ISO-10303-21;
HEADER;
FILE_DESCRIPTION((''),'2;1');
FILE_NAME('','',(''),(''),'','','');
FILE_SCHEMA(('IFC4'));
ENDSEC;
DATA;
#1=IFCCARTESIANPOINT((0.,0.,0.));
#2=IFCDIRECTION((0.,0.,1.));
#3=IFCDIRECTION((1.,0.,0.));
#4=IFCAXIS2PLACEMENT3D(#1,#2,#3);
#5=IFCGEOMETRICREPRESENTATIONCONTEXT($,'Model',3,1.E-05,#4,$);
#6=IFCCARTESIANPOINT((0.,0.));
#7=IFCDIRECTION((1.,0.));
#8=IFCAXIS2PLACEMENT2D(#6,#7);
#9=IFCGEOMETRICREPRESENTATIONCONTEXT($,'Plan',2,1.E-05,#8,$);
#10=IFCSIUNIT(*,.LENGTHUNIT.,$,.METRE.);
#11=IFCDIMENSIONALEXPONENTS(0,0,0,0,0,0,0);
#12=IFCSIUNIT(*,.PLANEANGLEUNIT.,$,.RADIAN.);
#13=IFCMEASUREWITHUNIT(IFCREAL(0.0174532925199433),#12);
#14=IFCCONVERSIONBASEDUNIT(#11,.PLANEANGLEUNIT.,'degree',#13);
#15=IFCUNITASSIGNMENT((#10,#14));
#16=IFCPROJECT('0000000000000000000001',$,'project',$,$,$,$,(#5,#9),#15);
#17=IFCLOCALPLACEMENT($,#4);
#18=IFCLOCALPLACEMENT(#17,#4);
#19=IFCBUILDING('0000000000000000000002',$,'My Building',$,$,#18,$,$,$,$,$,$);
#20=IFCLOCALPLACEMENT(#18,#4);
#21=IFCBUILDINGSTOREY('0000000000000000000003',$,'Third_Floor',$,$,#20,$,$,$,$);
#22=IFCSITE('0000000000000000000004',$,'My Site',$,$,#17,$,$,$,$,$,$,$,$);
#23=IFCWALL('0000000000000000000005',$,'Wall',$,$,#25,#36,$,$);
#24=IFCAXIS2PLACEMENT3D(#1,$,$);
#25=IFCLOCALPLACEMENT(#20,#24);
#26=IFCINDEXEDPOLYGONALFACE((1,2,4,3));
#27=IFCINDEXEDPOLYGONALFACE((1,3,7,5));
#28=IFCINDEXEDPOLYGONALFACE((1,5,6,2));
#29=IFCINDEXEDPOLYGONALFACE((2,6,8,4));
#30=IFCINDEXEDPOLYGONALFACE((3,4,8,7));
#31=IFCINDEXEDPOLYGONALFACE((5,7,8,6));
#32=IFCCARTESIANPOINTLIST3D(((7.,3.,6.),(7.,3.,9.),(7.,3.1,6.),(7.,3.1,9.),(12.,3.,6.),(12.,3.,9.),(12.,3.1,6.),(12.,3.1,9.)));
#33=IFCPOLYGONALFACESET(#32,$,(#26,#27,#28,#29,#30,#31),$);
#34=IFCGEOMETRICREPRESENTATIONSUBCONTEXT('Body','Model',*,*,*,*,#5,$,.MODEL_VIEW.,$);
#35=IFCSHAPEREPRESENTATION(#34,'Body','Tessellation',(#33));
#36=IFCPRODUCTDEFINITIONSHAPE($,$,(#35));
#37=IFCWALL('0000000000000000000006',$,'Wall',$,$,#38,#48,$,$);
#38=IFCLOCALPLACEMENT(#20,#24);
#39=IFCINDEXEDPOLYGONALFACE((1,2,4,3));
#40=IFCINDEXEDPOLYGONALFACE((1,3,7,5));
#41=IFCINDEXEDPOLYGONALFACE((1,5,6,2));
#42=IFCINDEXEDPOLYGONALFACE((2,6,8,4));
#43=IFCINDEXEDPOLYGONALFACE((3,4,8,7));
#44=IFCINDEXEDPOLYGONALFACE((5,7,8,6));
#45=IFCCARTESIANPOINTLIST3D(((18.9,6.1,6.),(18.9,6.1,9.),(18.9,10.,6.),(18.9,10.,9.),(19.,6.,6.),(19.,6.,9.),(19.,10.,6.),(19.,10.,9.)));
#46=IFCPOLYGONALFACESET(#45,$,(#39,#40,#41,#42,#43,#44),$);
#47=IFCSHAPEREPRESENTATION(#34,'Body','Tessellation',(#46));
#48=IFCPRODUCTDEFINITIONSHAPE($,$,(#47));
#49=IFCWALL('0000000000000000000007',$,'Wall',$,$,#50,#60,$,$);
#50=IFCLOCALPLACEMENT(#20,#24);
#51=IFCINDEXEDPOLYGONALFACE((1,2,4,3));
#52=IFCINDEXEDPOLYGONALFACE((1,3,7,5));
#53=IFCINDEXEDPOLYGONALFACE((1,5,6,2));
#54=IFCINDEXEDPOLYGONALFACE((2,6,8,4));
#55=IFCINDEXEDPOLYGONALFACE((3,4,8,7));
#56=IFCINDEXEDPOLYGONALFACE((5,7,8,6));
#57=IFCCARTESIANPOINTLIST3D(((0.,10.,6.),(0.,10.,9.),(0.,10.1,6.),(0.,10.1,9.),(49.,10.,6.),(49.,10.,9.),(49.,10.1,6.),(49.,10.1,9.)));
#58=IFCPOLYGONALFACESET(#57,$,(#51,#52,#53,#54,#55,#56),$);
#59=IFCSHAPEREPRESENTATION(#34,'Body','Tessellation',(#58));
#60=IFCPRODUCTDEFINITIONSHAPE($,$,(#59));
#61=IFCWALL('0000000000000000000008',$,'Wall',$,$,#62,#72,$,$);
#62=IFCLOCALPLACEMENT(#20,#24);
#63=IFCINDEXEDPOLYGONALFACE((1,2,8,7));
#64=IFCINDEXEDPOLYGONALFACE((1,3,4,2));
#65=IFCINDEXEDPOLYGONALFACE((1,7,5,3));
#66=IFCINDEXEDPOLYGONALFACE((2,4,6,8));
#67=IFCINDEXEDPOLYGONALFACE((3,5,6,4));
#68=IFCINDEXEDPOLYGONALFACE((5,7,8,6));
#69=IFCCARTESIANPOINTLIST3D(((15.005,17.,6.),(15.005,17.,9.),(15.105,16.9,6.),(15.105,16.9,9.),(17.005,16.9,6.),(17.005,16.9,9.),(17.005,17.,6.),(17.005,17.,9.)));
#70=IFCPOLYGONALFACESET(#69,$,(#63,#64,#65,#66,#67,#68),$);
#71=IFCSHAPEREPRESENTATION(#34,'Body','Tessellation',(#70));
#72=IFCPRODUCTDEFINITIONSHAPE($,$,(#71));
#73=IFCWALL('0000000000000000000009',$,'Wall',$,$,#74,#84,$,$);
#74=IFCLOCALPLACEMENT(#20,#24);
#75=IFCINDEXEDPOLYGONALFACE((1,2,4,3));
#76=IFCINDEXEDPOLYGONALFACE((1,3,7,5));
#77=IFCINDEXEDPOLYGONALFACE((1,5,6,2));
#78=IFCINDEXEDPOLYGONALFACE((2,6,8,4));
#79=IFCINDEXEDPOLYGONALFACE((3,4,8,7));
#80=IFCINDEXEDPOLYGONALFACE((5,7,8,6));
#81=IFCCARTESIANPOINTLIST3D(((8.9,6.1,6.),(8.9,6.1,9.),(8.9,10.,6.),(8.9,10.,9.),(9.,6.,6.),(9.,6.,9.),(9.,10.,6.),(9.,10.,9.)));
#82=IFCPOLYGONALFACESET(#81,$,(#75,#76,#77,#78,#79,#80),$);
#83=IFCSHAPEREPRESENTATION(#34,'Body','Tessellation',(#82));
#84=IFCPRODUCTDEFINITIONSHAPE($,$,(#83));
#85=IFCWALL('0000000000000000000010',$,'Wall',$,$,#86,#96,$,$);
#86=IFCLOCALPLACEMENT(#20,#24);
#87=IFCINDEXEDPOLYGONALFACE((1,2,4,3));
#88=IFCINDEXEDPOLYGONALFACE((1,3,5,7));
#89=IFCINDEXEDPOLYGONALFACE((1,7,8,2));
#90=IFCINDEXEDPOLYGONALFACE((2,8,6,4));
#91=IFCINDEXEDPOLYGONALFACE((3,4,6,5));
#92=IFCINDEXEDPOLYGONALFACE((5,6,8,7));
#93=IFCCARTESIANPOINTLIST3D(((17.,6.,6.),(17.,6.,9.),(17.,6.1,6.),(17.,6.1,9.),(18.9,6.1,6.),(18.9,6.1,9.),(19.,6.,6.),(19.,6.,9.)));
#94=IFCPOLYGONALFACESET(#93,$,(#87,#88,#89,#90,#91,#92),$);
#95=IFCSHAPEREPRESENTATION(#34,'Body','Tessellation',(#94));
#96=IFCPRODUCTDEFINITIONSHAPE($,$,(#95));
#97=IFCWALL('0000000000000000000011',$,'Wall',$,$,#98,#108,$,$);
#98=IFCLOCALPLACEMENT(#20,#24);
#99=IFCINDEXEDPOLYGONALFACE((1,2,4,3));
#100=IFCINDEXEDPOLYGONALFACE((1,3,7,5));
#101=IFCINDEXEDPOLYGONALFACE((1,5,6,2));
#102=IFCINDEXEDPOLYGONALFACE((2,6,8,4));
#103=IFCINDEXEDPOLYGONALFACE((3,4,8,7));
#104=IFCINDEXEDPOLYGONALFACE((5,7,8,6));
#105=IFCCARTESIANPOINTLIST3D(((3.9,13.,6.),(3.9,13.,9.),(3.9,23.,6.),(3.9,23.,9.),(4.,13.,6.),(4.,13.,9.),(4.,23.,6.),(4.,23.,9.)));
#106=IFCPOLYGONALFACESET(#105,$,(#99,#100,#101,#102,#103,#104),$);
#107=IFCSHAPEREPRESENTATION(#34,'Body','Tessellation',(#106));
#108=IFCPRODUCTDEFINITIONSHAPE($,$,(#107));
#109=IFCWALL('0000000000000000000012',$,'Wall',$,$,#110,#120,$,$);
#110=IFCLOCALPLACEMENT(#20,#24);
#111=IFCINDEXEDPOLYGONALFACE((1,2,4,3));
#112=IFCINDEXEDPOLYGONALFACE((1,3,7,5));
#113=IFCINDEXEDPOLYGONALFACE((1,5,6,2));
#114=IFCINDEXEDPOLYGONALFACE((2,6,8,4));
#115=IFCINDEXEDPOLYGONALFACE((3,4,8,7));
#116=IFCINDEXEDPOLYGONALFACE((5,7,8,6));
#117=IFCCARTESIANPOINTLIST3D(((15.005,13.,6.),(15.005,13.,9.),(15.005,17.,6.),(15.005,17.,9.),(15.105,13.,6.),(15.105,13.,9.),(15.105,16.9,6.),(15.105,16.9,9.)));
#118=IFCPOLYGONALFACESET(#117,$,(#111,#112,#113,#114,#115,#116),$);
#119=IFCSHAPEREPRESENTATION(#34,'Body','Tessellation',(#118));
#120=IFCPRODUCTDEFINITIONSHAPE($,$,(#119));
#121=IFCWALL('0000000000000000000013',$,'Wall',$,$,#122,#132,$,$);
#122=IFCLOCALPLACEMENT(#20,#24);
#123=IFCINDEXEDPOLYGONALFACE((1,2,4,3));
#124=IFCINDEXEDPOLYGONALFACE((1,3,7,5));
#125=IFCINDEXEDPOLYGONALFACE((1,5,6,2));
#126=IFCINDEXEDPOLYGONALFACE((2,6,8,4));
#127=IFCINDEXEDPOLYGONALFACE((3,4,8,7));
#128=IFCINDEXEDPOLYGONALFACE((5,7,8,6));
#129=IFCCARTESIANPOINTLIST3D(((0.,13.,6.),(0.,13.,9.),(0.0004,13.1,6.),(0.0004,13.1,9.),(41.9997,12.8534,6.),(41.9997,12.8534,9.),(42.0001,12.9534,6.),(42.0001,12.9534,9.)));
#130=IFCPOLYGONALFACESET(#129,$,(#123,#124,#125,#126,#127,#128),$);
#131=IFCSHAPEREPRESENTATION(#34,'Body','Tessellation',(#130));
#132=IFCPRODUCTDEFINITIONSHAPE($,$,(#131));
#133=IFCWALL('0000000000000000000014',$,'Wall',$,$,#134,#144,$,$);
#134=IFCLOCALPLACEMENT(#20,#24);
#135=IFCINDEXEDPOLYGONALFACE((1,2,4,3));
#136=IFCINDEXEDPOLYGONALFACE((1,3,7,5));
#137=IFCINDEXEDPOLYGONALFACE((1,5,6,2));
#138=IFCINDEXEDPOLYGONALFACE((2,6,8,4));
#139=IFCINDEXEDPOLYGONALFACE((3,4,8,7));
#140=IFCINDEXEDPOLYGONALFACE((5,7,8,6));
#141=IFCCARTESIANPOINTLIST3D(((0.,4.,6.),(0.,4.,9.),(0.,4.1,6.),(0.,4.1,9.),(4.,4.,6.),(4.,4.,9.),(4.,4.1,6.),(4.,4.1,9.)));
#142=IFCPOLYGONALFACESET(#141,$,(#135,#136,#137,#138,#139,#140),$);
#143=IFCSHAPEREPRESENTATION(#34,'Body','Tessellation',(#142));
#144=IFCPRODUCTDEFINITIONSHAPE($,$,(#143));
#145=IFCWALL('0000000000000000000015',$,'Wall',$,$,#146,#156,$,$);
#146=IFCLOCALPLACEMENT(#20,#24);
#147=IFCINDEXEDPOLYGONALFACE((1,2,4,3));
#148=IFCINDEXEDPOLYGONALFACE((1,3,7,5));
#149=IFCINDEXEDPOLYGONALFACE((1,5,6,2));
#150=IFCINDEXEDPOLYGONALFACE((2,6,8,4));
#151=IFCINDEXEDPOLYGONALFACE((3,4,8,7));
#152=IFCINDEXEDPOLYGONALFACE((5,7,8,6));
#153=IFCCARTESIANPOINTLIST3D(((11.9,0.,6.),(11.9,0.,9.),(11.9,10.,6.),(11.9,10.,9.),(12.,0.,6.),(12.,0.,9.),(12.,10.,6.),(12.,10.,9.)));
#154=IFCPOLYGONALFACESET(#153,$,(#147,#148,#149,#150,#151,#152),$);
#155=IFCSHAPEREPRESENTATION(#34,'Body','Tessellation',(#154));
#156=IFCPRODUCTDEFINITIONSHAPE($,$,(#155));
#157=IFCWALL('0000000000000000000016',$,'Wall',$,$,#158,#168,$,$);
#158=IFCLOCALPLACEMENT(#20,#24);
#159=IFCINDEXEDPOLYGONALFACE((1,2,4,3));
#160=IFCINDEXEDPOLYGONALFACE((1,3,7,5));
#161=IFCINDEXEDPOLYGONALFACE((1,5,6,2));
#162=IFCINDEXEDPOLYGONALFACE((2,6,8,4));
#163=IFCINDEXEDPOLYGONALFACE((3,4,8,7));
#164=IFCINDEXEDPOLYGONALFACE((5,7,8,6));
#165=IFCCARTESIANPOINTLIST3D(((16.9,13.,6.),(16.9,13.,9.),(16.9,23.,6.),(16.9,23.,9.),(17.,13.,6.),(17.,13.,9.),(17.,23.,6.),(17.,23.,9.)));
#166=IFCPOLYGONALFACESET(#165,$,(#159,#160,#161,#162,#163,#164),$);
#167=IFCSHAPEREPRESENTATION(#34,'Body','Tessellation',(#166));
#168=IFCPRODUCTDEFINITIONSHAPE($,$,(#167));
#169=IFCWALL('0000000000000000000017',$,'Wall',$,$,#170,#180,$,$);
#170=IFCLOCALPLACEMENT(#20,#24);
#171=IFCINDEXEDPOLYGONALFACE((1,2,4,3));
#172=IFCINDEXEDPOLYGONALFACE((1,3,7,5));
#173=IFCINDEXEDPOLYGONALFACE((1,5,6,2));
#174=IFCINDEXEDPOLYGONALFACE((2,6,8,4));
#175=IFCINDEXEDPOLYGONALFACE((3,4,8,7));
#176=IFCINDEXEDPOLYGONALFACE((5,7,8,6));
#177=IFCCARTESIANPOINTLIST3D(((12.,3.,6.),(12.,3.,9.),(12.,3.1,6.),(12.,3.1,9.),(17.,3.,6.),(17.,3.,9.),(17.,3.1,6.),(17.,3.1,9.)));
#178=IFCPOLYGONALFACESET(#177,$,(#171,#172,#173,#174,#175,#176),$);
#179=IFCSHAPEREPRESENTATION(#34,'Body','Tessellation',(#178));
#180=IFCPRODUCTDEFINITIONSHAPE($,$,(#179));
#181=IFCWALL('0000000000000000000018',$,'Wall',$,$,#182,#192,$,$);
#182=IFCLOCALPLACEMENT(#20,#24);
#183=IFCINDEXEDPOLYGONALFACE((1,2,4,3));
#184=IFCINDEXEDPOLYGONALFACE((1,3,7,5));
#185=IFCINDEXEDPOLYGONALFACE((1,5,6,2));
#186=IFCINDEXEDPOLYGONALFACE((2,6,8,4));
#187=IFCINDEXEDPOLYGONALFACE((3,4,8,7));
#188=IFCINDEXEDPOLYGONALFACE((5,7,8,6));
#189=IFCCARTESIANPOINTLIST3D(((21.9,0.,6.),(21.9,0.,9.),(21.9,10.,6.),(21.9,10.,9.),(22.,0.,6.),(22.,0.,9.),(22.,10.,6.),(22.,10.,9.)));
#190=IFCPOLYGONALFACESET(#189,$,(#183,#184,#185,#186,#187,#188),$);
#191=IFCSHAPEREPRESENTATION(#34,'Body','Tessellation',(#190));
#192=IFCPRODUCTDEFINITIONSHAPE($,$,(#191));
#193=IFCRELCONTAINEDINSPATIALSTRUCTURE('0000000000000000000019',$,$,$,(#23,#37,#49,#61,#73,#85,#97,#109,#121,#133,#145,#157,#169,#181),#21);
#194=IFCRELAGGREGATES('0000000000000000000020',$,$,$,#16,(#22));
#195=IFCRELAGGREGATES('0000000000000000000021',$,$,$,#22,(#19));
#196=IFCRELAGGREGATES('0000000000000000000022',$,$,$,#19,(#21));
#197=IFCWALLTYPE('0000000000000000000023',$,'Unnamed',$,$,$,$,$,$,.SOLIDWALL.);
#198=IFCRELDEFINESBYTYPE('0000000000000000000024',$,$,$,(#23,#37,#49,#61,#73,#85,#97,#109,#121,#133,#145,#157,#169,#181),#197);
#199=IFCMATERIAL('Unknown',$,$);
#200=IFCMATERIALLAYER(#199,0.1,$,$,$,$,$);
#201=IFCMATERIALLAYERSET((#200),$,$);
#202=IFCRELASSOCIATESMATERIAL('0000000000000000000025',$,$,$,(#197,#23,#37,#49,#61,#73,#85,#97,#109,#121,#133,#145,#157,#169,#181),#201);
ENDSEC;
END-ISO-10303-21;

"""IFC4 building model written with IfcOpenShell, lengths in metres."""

from ifc_helpers import new_model, entity, si_unit, converted_unit, frame, origin_with_axes, origin_2d_with_axis, place, context, subcontext, project, spatial, line, indexed_curve, outline, extrude, material, layer, layer_set, layer_usage, type_object, element, save


model = new_model("IFC4")

# Units and contexts
model_context = context("Model", 3, precision=1e-05, world=origin_with_axes())
plan_context = context("Plan", 2, precision=1e-05, world=origin_2d_with_axis())
body_context = subcontext(model_context, "Body", "Model", "MODEL_VIEW")
ifc_project = project(units=[si_unit("LENGTHUNIT", "METRE"), converted_unit("PLANEANGLEUNIT", "degree", entity("IfcReal", 0.0174532925199433), si_unit("PLANEANGLEUNIT", "RADIAN"), dimensions=[0, 0, 0, 0, 0, 0, 0])], contexts=[model_context, plan_context])

# Site, building, storey
site_placement = place(None, origin_with_axes())
site = spatial("IfcSite", under=ifc_project, at=site_placement, Name="My Site")
building_placement = place(site_placement, origin_with_axes())
building = spatial("IfcBuilding", under=site, at=building_placement, Name="My Building")
storey_placement = place(building_placement, origin_with_axes())
storey = spatial("IfcBuildingStorey", under=building, at=storey_placement, Name="Third_Floor")

# Shared definitions
ifc_material = material(Name="Unknown")

# Walls
ifc_layer_1 = layer(ifc_material, 0.1)
ifc_layer_set_1 = layer_set([ifc_layer_1])
wall_type = type_object("IfcWallType", Name="Unnamed", PredefinedType="SOLIDWALL", material=ifc_layer_set_1)
ifc_layer_usage_1 = layer_usage(ifc_layer_set_1, "AXIS2", "POSITIVE", 0.0)
wall_1_placement = place(storey_placement, frame((7.0, 3.0, 6.0), z_axis=(0.0, 0.0, 1.0), x_axis=(1.0, 0.0, 0.0)))
element("IfcWall", 1, at=wall_1_placement, inside=storey, type_object=wall_type, material=ifc_layer_usage_1, Name="Wall", context=body_context, shape_type="SweptSolid", body=[
    extrude(outline(indexed_curve([(0.0, 0.0), (0.0, 0.1), (5.0, 0.1), (5.0, 0.0)], segments=[line(1, 2, 3, 4, 1)])), origin_with_axes(), (0.0, 0.0, 1.0), 3.0),
])
ifc_layer_usage_2 = layer_usage(ifc_layer_set_1, "AXIS2", "POSITIVE", 0.0)
wall_2_placement = place(storey_placement, frame((19.0, 6.0, 6.0), z_axis=(0.0, 0.0, 1.0), x_axis=(0.0, 1.0, 0.0)))
element("IfcWall", 2, at=wall_2_placement, inside=storey, type_object=wall_type, material=ifc_layer_usage_2, Name="Wall", context=body_context, shape_type="SweptSolid", body=[
    extrude(outline(indexed_curve([(0.0, 0.0), (0.1, 0.1), (4.0, 0.1), (4.0, 0.0)], segments=[line(1, 2, 3, 4, 1)])), origin_with_axes(), (0.0, 0.0, 1.0), 3.0),
])
ifc_layer_usage_3 = layer_usage(ifc_layer_set_1, "AXIS2", "POSITIVE", 0.0)
wall_3_placement = place(storey_placement, frame((0.0, 10.0, 6.0), z_axis=(0.0, 0.0, 1.0), x_axis=(1.0, 0.0, 0.0)))
element("IfcWall", 3, at=wall_3_placement, inside=storey, type_object=wall_type, material=ifc_layer_usage_3, Name="Wall", context=body_context, shape_type="SweptSolid", body=[
    extrude(outline(indexed_curve([(0.0, 0.0), (0.0, 0.1), (49.0, 0.1), (49.0, 0.0)], segments=[line(1, 2, 3, 4, 1)])), origin_with_axes(), (0.0, 0.0, 1.0), 3.0),
])
ifc_layer_usage_4 = layer_usage(ifc_layer_set_1, "AXIS2", "POSITIVE", 0.0)
wall_4_placement = place(storey_placement, frame((17.005, 17.0, 6.0), z_axis=(0.0, 0.0, 1.0), x_axis=(-1.0, 0.0, 0.0)))
element("IfcWall", 4, at=wall_4_placement, inside=storey, type_object=wall_type, material=ifc_layer_usage_4, Name="Wall", context=body_context, shape_type="SweptSolid", body=[
    extrude(outline(indexed_curve([(0.0, 0.0), (0.0, 0.1), (1.9, 0.1), (2.0, 0.0)], segments=[line(1, 2, 3, 4, 1)])), origin_with_axes(), (0.0, 0.0, 1.0), 3.0),
])
ifc_layer_usage_5 = layer_usage(ifc_layer_set_1, "AXIS2", "POSITIVE", 0.0)
wall_5_placement = place(storey_placement, frame((9.0, 6.0, 6.0), z_axis=(0.0, 0.0, 1.0), x_axis=(0.0, 1.0, 0.0)))
element("IfcWall", 5, at=wall_5_placement, inside=storey, type_object=wall_type, material=ifc_layer_usage_5, Name="Wall", context=body_context, shape_type="SweptSolid", body=[
    extrude(outline(indexed_curve([(0.0, 0.0), (0.1, 0.1), (4.0, 0.1), (4.0, 0.0)], segments=[line(1, 2, 3, 4, 1)])), origin_with_axes(), (0.0, 0.0, 1.0), 3.0),
])
ifc_layer_usage_6 = layer_usage(ifc_layer_set_1, "AXIS2", "POSITIVE", 0.0)
wall_6_placement = place(storey_placement, frame((17.0, 6.0, 6.0), z_axis=(0.0, 0.0, 1.0), x_axis=(1.0, 0.0, 0.0)))
element("IfcWall", 6, at=wall_6_placement, inside=storey, type_object=wall_type, material=ifc_layer_usage_6, Name="Wall", context=body_context, shape_type="SweptSolid", body=[
    extrude(outline(indexed_curve([(0.0, 0.0), (0.0, 0.1), (1.9, 0.1), (2.0, 0.0)], segments=[line(1, 2, 3, 4, 1)])), origin_with_axes(), (0.0, 0.0, 1.0), 3.0),
])
ifc_layer_usage_7 = layer_usage(ifc_layer_set_1, "AXIS2", "POSITIVE", 0.0)
wall_7_placement = place(storey_placement, frame((3.9, 23.0, 6.0), z_axis=(0.0, 0.0, 1.0), x_axis=(0.0, -1.0, 0.0)))
element("IfcWall", 7, at=wall_7_placement, inside=storey, type_object=wall_type, material=ifc_layer_usage_7, Name="Wall", context=body_context, shape_type="SweptSolid", body=[
    extrude(outline(indexed_curve([(0.0, 0.0), (0.0, 0.1), (10.0, 0.1), (10.0, 0.0)], segments=[line(1, 2, 3, 4, 1)])), origin_with_axes(), (0.0, 0.0, 1.0), 3.0),
])
ifc_layer_usage_8 = layer_usage(ifc_layer_set_1, "AXIS2", "POSITIVE", 0.0)
wall_8_placement = place(storey_placement, frame((15.005, 17.0, 6.0), z_axis=(0.0, 0.0, 1.0), x_axis=(0.0, -1.0, 0.0)))
element("IfcWall", 8, at=wall_8_placement, inside=storey, type_object=wall_type, material=ifc_layer_usage_8, Name="Wall", context=body_context, shape_type="SweptSolid", body=[
    extrude(outline(indexed_curve([(0.0, 0.0), (0.1, 0.1), (4.0, 0.1), (4.0, 0.0)], segments=[line(1, 2, 3, 4, 1)])), origin_with_axes(), (0.0, 0.0, 1.0), 3.0),
])
ifc_layer_usage_9 = layer_usage(ifc_layer_set_1, "AXIS2", "POSITIVE", 0.0)
wall_9_placement = place(storey_placement, frame((0.0, 13.0, 6.0), z_axis=(0.0, 0.0, 1.0), x_axis=(0.999994, -0.003491, 0.0)))
element("IfcWall", 9, at=wall_9_placement, inside=storey, type_object=wall_type, material=ifc_layer_usage_9, Name="Wall", context=body_context, shape_type="SweptSolid", body=[
    extrude(outline(indexed_curve([(0.0, 0.0), (0.0, 0.1), (42.0, 0.1), (42.0, 0.0)], segments=[line(1, 2, 3, 4, 1)])), origin_with_axes(), (0.0, 0.0, 1.0), 3.0),
])
ifc_layer_usage_10 = layer_usage(ifc_layer_set_1, "AXIS2", "POSITIVE", 0.0)
wall_10_placement = place(storey_placement, frame((0.0, 4.0, 6.0), z_axis=(0.0, 0.0, 1.0), x_axis=(1.0, 0.0, 0.0)))
element("IfcWall", 10, at=wall_10_placement, inside=storey, type_object=wall_type, material=ifc_layer_usage_10, Name="Wall", context=body_context, shape_type="SweptSolid", body=[
    extrude(outline(indexed_curve([(0.0, 0.0), (0.0, 0.1), (4.0, 0.1), (4.0, 0.0)], segments=[line(1, 2, 3, 4, 1)])), origin_with_axes(), (0.0, 0.0, 1.0), 3.0),
])
ifc_layer_usage_11 = layer_usage(ifc_layer_set_1, "AXIS2", "POSITIVE", 0.0)
wall_11_placement = place(storey_placement, frame((11.9, 10.0, 6.0), z_axis=(0.0, 0.0, 1.0), x_axis=(0.0, -1.0, 0.0)))
element("IfcWall", 11, at=wall_11_placement, inside=storey, type_object=wall_type, material=ifc_layer_usage_11, Name="Wall", context=body_context, shape_type="SweptSolid", body=[
    extrude(outline(indexed_curve([(0.0, 0.0), (0.0, 0.1), (10.0, 0.1), (10.0, 0.0)], segments=[line(1, 2, 3, 4, 1)])), origin_with_axes(), (0.0, 0.0, 1.0), 3.0),
])
ifc_layer_usage_12 = layer_usage(ifc_layer_set_1, "AXIS2", "POSITIVE", 0.0)
wall_12_placement = place(storey_placement, frame((16.9, 23.0, 6.0), z_axis=(0.0, 0.0, 1.0), x_axis=(0.0, -1.0, 0.0)))
element("IfcWall", 12, at=wall_12_placement, inside=storey, type_object=wall_type, material=ifc_layer_usage_12, Name="Wall", context=body_context, shape_type="SweptSolid", body=[
    extrude(outline(indexed_curve([(0.0, 0.0), (0.0, 0.1), (10.0, 0.1), (10.0, 0.0)], segments=[line(1, 2, 3, 4, 1)])), origin_with_axes(), (0.0, 0.0, 1.0), 3.0),
])
ifc_layer_usage_13 = layer_usage(ifc_layer_set_1, "AXIS2", "POSITIVE", 0.0)
wall_13_placement = place(storey_placement, frame((12.0, 3.0, 6.0), z_axis=(0.0, 0.0, 1.0), x_axis=(1.0, 0.0, 0.0)))
element("IfcWall", 13, at=wall_13_placement, inside=storey, type_object=wall_type, material=ifc_layer_usage_13, Name="Wall", context=body_context, shape_type="SweptSolid", body=[
    extrude(outline(indexed_curve([(0.0, 0.0), (0.0, 0.1), (5.0, 0.1), (5.0, 0.0)], segments=[line(1, 2, 3, 4, 1)])), origin_with_axes(), (0.0, 0.0, 1.0), 3.0),
])
ifc_layer_usage_14 = layer_usage(ifc_layer_set_1, "AXIS2", "POSITIVE", 0.0)
wall_14_placement = place(storey_placement, frame((21.9, 10.0, 6.0), z_axis=(0.0, 0.0, 1.0), x_axis=(0.0, -1.0, 0.0)))
element("IfcWall", 14, at=wall_14_placement, inside=storey, type_object=wall_type, material=ifc_layer_usage_14, Name="Wall", context=body_context, shape_type="SweptSolid", body=[
    extrude(outline(indexed_curve([(0.0, 0.0), (0.0, 0.1), (10.0, 0.1), (10.0, 0.0)], segments=[line(1, 2, 3, 4, 1)])), origin_with_axes(), (0.0, 0.0, 1.0), 3.0),
])

save(model, "model.ifc")
